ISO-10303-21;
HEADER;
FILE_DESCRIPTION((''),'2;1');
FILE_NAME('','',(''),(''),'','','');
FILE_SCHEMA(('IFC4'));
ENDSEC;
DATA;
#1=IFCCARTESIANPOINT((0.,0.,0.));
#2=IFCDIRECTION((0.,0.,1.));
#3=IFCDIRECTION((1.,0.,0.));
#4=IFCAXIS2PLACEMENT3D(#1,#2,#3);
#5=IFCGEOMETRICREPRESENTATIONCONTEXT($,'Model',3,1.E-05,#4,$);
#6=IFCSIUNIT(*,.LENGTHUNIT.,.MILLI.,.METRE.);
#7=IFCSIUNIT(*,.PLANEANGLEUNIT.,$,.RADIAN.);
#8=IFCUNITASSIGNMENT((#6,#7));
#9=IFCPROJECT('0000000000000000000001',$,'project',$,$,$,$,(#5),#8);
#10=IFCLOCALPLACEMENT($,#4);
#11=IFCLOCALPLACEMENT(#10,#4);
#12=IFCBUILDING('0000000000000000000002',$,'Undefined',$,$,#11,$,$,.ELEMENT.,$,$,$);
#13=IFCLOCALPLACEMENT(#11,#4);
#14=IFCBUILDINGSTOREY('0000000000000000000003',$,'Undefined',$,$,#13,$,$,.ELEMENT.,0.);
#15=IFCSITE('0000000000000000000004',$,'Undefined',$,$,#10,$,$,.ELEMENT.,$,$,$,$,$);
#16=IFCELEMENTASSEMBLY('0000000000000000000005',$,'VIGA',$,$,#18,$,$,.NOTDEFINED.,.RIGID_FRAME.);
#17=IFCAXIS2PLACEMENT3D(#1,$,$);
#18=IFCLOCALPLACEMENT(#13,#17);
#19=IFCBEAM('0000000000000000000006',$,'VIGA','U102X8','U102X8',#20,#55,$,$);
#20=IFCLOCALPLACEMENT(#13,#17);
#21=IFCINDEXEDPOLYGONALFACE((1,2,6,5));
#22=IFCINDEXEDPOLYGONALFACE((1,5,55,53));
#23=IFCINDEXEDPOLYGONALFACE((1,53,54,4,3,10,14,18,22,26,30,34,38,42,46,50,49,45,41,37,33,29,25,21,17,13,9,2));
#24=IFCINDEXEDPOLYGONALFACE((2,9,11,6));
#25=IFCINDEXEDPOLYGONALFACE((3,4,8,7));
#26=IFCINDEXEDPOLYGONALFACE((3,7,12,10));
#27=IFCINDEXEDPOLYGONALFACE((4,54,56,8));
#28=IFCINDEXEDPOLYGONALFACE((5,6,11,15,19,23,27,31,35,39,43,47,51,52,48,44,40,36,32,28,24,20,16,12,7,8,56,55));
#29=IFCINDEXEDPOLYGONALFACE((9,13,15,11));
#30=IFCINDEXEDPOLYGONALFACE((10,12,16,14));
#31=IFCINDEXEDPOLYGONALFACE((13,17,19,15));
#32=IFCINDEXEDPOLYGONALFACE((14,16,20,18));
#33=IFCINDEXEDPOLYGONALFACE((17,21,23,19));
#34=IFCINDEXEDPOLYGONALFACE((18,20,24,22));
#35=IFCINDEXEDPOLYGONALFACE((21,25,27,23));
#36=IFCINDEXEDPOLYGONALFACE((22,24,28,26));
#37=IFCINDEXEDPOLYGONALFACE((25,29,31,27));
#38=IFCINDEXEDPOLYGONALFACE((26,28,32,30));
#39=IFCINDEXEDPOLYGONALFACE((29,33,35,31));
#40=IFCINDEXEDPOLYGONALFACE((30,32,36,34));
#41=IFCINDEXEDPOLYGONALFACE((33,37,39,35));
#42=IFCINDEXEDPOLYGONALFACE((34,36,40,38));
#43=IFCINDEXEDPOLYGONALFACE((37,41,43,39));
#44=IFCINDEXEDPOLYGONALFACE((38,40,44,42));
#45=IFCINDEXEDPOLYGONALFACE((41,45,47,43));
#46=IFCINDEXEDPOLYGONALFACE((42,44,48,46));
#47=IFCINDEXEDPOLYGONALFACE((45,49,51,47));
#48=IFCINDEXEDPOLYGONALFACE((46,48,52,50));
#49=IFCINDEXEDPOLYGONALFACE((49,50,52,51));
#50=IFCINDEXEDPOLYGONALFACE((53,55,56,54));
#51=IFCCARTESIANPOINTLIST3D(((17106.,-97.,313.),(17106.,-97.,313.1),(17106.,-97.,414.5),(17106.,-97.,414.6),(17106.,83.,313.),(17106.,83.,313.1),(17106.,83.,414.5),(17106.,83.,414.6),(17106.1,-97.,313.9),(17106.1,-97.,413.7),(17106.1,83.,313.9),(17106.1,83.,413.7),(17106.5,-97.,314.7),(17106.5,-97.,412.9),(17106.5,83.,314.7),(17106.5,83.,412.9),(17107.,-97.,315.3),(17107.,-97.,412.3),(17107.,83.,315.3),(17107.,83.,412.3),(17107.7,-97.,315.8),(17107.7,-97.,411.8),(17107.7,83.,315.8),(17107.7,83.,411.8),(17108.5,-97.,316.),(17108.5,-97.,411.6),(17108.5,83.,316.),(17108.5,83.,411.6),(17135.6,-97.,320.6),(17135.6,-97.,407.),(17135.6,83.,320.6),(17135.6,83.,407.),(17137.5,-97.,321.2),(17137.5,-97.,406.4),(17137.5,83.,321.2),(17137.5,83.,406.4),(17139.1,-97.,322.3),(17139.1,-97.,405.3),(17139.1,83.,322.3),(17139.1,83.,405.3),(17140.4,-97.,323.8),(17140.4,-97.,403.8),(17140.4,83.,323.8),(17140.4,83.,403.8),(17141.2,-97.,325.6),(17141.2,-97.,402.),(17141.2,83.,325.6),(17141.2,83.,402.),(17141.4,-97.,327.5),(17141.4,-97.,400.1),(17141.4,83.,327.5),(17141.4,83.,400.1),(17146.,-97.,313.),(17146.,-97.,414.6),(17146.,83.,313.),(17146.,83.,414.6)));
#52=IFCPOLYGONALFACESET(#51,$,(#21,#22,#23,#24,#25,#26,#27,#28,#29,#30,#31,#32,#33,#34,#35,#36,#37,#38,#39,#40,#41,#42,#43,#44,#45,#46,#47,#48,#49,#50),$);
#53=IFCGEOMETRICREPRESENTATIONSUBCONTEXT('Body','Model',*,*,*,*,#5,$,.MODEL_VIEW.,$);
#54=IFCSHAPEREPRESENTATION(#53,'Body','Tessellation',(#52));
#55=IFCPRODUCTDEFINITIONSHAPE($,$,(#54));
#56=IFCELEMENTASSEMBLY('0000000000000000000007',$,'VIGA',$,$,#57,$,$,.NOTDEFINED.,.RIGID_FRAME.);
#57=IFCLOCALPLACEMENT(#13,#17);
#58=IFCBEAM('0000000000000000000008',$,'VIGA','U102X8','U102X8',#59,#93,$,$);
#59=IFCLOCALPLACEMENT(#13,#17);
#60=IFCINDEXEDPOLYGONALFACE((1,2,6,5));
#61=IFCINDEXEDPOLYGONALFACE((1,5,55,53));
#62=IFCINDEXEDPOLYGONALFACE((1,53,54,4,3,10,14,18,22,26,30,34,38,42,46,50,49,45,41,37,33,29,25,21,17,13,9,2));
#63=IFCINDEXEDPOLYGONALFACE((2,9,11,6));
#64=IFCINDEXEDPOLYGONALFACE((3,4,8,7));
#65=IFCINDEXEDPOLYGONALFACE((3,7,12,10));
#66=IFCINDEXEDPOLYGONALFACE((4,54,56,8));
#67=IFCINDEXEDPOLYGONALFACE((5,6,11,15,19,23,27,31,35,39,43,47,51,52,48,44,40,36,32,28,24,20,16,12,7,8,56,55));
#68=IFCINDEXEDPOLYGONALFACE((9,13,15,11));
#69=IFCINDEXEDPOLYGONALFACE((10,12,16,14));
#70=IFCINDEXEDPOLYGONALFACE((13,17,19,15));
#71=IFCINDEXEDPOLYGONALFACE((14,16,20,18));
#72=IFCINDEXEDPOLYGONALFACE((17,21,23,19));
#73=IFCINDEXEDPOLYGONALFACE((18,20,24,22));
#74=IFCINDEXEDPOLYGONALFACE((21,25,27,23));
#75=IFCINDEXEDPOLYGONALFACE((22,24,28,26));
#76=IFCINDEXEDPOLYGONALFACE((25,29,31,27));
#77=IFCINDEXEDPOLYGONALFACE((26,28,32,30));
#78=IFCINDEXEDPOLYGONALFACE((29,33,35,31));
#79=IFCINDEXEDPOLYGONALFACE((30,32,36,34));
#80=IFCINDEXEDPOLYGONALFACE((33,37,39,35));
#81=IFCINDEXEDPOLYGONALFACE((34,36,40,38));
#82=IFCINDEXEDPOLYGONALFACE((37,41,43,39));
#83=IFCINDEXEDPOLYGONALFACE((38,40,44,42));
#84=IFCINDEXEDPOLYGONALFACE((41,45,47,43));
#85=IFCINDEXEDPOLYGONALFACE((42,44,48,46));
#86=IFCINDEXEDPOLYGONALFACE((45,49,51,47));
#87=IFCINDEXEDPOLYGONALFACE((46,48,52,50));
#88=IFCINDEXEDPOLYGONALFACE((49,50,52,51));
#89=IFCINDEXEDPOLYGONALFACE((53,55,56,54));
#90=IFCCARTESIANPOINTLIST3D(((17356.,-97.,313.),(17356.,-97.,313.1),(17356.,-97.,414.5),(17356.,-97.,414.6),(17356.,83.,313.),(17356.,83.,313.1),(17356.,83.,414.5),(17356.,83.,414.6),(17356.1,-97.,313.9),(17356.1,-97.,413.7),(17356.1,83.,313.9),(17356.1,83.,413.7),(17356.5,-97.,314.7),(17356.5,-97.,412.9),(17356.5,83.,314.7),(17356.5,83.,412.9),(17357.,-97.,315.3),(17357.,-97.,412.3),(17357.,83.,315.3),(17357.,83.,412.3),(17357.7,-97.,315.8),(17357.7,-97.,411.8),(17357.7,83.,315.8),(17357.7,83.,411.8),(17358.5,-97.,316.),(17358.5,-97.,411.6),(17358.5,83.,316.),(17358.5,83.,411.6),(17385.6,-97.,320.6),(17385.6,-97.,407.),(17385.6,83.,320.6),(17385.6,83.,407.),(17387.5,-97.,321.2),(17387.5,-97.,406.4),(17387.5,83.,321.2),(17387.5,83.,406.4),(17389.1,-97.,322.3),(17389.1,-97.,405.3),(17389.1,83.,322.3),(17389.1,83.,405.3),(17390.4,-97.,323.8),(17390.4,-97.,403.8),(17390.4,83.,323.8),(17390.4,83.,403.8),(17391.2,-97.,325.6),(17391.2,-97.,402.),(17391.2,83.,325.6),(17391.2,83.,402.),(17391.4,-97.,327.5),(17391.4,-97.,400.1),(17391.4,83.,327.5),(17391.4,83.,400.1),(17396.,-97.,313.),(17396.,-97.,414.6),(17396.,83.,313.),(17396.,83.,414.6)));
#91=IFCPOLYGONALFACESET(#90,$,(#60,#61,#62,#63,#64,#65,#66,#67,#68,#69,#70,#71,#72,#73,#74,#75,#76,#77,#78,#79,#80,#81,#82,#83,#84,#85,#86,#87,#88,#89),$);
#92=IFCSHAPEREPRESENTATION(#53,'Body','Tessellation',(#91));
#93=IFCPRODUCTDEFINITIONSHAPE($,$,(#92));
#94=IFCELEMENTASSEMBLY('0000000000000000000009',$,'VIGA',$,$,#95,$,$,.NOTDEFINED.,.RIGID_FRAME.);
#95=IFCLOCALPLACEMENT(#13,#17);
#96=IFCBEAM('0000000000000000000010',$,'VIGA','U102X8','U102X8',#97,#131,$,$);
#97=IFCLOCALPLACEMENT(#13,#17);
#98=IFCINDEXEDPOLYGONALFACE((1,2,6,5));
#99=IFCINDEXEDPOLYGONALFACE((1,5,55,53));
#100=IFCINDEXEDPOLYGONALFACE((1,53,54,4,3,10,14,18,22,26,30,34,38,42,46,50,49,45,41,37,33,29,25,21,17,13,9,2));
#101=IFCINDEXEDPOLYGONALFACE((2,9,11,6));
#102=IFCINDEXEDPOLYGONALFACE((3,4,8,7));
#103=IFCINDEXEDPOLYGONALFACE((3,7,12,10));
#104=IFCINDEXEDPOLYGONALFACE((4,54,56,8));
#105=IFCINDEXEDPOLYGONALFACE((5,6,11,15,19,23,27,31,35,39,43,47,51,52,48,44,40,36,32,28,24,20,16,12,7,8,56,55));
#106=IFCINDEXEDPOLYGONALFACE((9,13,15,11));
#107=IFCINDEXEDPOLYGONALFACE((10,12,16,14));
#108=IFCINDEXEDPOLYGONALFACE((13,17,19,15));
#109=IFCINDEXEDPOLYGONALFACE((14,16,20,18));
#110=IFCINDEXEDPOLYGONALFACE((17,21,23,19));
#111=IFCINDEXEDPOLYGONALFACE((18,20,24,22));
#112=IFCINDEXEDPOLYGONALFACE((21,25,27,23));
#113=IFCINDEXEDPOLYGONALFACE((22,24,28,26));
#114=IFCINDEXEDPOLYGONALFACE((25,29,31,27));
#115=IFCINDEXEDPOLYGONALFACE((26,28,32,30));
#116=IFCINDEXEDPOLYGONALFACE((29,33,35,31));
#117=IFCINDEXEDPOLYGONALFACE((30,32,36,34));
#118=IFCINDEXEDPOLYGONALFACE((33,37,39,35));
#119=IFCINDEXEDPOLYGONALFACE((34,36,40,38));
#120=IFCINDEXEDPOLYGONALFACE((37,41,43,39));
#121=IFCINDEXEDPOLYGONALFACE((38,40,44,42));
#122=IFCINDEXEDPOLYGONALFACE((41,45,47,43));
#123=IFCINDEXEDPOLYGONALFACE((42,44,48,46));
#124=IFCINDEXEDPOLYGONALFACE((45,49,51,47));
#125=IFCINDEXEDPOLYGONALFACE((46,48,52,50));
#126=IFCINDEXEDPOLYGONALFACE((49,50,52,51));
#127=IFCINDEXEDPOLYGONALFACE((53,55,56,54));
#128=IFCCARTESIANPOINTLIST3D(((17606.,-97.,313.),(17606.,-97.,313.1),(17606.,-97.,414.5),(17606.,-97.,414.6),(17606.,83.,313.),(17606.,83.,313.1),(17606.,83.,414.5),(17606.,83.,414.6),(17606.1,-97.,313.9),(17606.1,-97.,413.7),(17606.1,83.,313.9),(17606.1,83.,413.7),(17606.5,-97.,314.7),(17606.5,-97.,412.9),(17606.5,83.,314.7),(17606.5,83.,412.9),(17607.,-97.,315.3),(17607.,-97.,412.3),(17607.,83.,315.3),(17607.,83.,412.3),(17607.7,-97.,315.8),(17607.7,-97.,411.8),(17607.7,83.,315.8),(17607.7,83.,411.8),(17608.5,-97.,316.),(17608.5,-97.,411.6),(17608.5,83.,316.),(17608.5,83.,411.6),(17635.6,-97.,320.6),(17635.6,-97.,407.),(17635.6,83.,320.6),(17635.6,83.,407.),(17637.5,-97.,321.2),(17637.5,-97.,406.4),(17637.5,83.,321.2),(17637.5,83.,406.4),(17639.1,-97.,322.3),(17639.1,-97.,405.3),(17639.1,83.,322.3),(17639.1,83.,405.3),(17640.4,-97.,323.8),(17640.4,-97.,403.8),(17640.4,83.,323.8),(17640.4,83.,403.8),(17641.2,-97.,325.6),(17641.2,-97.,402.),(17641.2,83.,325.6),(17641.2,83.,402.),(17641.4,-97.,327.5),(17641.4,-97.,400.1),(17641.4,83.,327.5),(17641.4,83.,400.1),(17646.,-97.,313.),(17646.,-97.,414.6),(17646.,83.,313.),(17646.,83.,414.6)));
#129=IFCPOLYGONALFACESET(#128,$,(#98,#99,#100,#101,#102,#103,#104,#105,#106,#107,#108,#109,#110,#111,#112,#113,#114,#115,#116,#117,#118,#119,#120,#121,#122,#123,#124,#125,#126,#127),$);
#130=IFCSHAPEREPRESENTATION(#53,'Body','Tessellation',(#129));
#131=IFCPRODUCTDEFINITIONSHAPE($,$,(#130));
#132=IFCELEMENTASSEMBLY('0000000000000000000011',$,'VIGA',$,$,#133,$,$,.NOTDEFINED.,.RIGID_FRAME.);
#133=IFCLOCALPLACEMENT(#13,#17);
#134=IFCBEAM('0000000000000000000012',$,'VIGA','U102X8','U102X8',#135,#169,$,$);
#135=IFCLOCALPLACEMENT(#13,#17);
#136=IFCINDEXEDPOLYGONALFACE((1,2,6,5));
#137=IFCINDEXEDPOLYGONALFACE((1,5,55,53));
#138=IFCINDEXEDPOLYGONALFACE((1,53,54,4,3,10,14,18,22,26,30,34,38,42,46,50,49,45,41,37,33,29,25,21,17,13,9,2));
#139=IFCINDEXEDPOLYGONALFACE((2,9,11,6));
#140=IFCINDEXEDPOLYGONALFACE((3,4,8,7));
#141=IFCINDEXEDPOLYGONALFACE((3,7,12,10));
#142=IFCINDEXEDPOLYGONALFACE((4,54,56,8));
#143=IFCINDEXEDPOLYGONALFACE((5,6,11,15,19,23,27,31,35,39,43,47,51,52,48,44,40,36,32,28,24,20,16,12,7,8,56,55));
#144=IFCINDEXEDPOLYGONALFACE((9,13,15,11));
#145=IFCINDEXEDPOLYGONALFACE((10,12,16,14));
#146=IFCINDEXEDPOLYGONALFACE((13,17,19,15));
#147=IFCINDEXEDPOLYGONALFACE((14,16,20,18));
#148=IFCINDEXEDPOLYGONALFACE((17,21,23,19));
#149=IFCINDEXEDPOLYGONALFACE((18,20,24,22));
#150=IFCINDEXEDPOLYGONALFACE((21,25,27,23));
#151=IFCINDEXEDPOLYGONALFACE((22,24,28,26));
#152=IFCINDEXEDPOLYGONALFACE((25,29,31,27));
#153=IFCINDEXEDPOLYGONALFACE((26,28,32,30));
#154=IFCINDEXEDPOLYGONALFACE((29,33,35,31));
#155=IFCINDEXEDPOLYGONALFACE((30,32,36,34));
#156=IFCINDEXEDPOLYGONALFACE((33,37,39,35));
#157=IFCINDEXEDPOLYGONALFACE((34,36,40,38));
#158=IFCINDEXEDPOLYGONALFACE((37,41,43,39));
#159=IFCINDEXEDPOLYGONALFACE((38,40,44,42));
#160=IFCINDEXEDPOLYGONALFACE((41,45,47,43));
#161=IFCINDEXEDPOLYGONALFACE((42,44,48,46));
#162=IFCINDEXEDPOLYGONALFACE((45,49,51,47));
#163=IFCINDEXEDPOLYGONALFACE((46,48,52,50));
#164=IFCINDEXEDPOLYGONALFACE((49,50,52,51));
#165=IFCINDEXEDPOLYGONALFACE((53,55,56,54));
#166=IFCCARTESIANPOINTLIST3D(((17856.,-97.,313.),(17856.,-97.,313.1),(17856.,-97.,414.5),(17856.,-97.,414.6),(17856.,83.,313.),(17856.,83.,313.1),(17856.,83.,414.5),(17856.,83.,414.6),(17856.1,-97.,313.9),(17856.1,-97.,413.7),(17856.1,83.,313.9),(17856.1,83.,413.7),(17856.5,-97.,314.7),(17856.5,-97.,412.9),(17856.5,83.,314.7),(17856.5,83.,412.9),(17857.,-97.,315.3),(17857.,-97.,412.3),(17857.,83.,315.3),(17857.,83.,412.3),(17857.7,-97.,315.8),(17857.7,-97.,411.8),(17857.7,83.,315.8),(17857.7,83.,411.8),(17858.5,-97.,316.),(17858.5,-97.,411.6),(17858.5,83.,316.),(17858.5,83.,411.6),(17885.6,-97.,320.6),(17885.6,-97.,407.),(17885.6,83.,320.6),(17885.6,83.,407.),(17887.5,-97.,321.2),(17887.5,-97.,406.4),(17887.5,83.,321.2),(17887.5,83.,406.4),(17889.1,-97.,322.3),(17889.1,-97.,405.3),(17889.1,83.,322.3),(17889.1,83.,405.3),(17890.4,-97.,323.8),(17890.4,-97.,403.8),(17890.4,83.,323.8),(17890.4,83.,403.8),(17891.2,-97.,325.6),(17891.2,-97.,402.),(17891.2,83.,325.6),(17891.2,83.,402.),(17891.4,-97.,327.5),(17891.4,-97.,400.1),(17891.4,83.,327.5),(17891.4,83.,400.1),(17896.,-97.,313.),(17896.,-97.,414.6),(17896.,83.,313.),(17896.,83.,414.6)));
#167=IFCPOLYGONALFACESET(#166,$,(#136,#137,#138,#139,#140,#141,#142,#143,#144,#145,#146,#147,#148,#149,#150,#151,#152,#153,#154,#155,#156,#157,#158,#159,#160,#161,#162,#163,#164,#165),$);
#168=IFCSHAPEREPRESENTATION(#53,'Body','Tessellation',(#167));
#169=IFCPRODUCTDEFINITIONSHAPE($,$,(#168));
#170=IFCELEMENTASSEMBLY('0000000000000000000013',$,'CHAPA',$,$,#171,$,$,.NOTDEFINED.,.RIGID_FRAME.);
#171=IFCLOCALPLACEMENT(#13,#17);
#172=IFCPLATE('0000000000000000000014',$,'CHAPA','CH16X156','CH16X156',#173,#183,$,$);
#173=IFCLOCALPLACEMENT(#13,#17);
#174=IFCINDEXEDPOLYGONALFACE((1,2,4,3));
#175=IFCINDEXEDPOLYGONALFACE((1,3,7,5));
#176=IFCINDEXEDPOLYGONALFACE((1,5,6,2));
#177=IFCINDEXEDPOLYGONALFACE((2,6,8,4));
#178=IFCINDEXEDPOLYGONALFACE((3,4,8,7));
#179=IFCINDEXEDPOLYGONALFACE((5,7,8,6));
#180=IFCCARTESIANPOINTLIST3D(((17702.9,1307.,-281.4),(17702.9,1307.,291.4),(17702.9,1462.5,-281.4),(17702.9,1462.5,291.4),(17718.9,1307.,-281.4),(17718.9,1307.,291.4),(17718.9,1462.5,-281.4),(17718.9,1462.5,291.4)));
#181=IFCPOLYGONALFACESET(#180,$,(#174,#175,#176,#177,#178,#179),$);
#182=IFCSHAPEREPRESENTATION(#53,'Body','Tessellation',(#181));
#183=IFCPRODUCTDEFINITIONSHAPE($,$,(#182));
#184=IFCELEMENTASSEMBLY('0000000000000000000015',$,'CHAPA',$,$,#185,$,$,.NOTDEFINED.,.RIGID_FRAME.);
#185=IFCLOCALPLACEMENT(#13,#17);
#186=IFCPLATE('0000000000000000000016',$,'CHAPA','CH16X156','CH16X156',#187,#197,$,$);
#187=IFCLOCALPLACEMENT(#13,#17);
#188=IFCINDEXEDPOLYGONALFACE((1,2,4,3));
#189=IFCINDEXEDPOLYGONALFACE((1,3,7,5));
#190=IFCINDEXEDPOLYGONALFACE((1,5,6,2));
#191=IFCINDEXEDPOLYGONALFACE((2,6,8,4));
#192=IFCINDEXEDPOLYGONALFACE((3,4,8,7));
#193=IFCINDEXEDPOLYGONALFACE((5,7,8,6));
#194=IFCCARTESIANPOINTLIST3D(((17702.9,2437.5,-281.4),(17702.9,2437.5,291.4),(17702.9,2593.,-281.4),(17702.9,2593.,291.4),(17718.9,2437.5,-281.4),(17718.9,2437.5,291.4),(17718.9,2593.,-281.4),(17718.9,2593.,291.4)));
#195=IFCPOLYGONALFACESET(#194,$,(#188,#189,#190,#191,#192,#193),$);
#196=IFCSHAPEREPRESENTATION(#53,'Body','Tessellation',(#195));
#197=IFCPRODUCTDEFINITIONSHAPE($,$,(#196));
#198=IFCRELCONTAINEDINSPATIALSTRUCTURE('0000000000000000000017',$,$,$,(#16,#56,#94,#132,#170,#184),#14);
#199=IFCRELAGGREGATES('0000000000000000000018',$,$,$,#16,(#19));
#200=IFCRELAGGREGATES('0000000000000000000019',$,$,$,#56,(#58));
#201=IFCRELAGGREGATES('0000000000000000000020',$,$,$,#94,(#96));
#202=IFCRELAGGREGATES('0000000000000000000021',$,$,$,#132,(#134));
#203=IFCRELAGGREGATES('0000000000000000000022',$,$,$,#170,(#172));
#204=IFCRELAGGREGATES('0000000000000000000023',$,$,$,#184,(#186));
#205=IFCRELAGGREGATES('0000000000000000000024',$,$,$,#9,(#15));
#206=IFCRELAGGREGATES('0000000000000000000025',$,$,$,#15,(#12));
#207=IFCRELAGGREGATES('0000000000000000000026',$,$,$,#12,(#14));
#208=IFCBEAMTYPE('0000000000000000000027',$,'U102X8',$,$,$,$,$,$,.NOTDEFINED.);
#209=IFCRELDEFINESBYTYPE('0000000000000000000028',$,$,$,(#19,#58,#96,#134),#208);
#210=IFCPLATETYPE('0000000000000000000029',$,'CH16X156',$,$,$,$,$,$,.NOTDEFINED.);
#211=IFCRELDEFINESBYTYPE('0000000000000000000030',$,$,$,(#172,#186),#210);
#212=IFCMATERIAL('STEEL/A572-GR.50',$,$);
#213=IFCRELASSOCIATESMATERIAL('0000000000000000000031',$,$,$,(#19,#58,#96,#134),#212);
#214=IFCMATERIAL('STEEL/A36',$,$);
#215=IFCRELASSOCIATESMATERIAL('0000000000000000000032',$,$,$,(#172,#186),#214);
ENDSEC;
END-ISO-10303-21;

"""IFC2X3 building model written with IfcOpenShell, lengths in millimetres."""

from ifc_helpers import new_model, si_unit, frame, origin_with_axes, origin_2d_with_axis, place, context, subcontext, project, spatial, polyline, u_section, outline, extrude, material, type_object, element, aggregate, save


model = new_model("IFC2X3")

# Units and contexts
model_context = context("Model", 3, precision=1e-05, world=origin_with_axes())
body_context = subcontext(model_context, "Body", "Model", "MODEL_VIEW")
ifc_project = project(units=[si_unit("LENGTHUNIT", "METRE", prefix="MILLI"), si_unit("PLANEANGLEUNIT", "RADIAN")], contexts=[model_context])

# Site, building, storey
site_placement = place(None, origin_with_axes())
site = spatial("IfcSite", under=ifc_project, at=site_placement, Name="Undefined", CompositionType="ELEMENT")
building_placement = place(site_placement, origin_with_axes())
building = spatial("IfcBuilding", under=site, at=building_placement, Name="Undefined", CompositionType="ELEMENT")
storey_placement = place(building_placement, origin_with_axes())
storey = spatial("IfcBuildingStorey", under=building, at=storey_placement, Name="Undefined", CompositionType="ELEMENT", Elevation=0.0)

# Element assemblies, beams
ifc_material_1 = material(Name="STEEL/A572-GR.50")
beam_type_1 = type_object("IfcBeamType", Name="U102X8", PredefinedType="NOTDEFINED")
assembly_1_placement = place(storey_placement, origin_with_axes())
assembly_1 = element("IfcElementAssembly", 1, at=assembly_1_placement, inside=storey, Name="VIGA", AssemblyPlace="NOTDEFINED", PredefinedType="RIGID_FRAME")
beam_1_placement = place(assembly_1_placement, frame((17126.0, 83.0, 363.8), z_axis=(0.0, 0.0, 1.0), x_axis=(0.0, -1.0, 0.0)))
beam_1 = element("IfcBeam", 2, at=beam_1_placement, type_object=beam_type_1, material=ifc_material_1, Name="VIGA", Description="U102X8", ObjectType="U102X8", context=body_context, shape_type="SweptSolid", body=[
    extrude(u_section(Depth=101.6, FlangeWidth=40.0, WebThickness=4.6, FlangeThickness=6.0, FilletRadius=7.0, EdgeRadius=3.0, FlangeSlope=0.16839, at=origin_2d_with_axis()), frame((180.0, 0.0, 0.0), z_axis=(-1.0, 0.0, 0.0), x_axis=(0.0, -1.0, 0.0)), (0.0, 0.0, 1.0), 180.0),
])
aggregate(assembly_1, [beam_1])
assembly_2_placement = place(storey_placement, origin_with_axes())
assembly_2 = element("IfcElementAssembly", 3, at=assembly_2_placement, inside=storey, Name="VIGA", AssemblyPlace="NOTDEFINED", PredefinedType="RIGID_FRAME")
beam_2_placement = place(assembly_2_placement, frame((17376.0, 83.0, 363.8), z_axis=(0.0, 0.0, 1.0), x_axis=(0.0, -1.0, 0.0)))
beam_2 = element("IfcBeam", 4, at=beam_2_placement, type_object=beam_type_1, material=ifc_material_1, Name="VIGA", Description="U102X8", ObjectType="U102X8", context=body_context, shape_type="SweptSolid", body=[
    extrude(u_section(Depth=101.6, FlangeWidth=40.0, WebThickness=4.6, FlangeThickness=6.0, FilletRadius=7.0, EdgeRadius=3.0, FlangeSlope=0.16839, at=origin_2d_with_axis()), frame((180.0, 0.0, 0.0), z_axis=(-1.0, 0.0, 0.0), x_axis=(0.0, -1.0, 0.0)), (0.0, 0.0, 1.0), 180.0),
])
aggregate(assembly_2, [beam_2])
assembly_3_placement = place(storey_placement, origin_with_axes())
assembly_3 = element("IfcElementAssembly", 5, at=assembly_3_placement, inside=storey, Name="VIGA", AssemblyPlace="NOTDEFINED", PredefinedType="RIGID_FRAME")
beam_3_placement = place(assembly_3_placement, frame((17626.0, 83.0, 363.8), z_axis=(0.0, 0.0, 1.0), x_axis=(0.0, -1.0, 0.0)))
beam_3 = element("IfcBeam", 6, at=beam_3_placement, type_object=beam_type_1, material=ifc_material_1, Name="VIGA", Description="U102X8", ObjectType="U102X8", context=body_context, shape_type="SweptSolid", body=[
    extrude(u_section(Depth=101.6, FlangeWidth=40.0, WebThickness=4.6, FlangeThickness=6.0, FilletRadius=7.0, EdgeRadius=3.0, FlangeSlope=0.16839, at=origin_2d_with_axis()), frame((180.0, 0.0, 0.0), z_axis=(-1.0, 0.0, 0.0), x_axis=(0.0, -1.0, 0.0)), (0.0, 0.0, 1.0), 180.0),
])
aggregate(assembly_3, [beam_3])
assembly_4_placement = place(storey_placement, origin_with_axes())
assembly_4 = element("IfcElementAssembly", 7, at=assembly_4_placement, inside=storey, Name="VIGA", AssemblyPlace="NOTDEFINED", PredefinedType="RIGID_FRAME")
beam_4_placement = place(assembly_4_placement, frame((17876.0, 83.0, 363.8), z_axis=(0.0, 0.0, 1.0), x_axis=(0.0, -1.0, 0.0)))
beam_4 = element("IfcBeam", 8, at=beam_4_placement, type_object=beam_type_1, material=ifc_material_1, Name="VIGA", Description="U102X8", ObjectType="U102X8", context=body_context, shape_type="SweptSolid", body=[
    extrude(u_section(Depth=101.6, FlangeWidth=40.0, WebThickness=4.6, FlangeThickness=6.0, FilletRadius=7.0, EdgeRadius=3.0, FlangeSlope=0.16839, at=origin_2d_with_axis()), frame((180.0, 0.0, 0.0), z_axis=(-1.0, 0.0, 0.0), x_axis=(0.0, -1.0, 0.0)), (0.0, 0.0, 1.0), 180.0),
])
aggregate(assembly_4, [beam_4])

# Element assemblies, plates
assembly_5_placement = place(storey_placement, origin_with_axes())
assembly_5 = element("IfcElementAssembly", 9, at=assembly_5_placement, inside=storey, Name="CHAPA", AssemblyPlace="NOTDEFINED", PredefinedType="RIGID_FRAME")
ifc_material_2 = material(Name="STEEL/A36")
plate_type = type_object("IfcPlateType", Name="CH16X156", PredefinedType="NOTDEFINED")
plate_1_placement = place(assembly_5_placement, frame((17710.9, 1462.5, 291.4), z_axis=(1.0, 0.0, 0.0), x_axis=(0.0, -1.0, 0.0)))
plate_1 = element("IfcPlate", 10, at=plate_1_placement, type_object=plate_type, material=ifc_material_2, Name="CHAPA", Description="CH16X156", ObjectType="CH16X156", context=body_context, shape_type="SweptSolid", body=[
    extrude(outline(polyline([(0.0, 0.0), (155.5, 0.0), (155.5, 572.8), (0.0, 572.8), (0.0, 0.0)])), frame((0.0, 0.0, -8.0), z_axis=(0.0, 0.0, 1.0), x_axis=(1.0, 0.0, 0.0)), (0.0, 0.0, 1.0), 16.0),
])
aggregate(assembly_5, [plate_1])
assembly_6_placement = place(storey_placement, origin_with_axes())
assembly_6 = element("IfcElementAssembly", 11, at=assembly_6_placement, inside=storey, Name="CHAPA", AssemblyPlace="NOTDEFINED", PredefinedType="RIGID_FRAME")
plate_2_placement = place(assembly_6_placement, frame((17710.9, 2593.0, 291.4), z_axis=(1.0, 0.0, 0.0), x_axis=(0.0, -1.0, 0.0)))
plate_2 = element("IfcPlate", 12, at=plate_2_placement, type_object=plate_type, material=ifc_material_2, Name="CHAPA", Description="CH16X156", ObjectType="CH16X156", context=body_context, shape_type="SweptSolid", body=[
    extrude(outline(polyline([(0.0, 0.0), (155.5, 0.0), (155.5, 572.8), (0.0, 572.8), (0.0, 0.0)])), frame((0.0, 0.0, -8.0), z_axis=(0.0, 0.0, 1.0), x_axis=(1.0, 0.0, 0.0)), (0.0, 0.0, 1.0), 16.0),
])
aggregate(assembly_6, [plate_2])

save(model, "model.ifc")
